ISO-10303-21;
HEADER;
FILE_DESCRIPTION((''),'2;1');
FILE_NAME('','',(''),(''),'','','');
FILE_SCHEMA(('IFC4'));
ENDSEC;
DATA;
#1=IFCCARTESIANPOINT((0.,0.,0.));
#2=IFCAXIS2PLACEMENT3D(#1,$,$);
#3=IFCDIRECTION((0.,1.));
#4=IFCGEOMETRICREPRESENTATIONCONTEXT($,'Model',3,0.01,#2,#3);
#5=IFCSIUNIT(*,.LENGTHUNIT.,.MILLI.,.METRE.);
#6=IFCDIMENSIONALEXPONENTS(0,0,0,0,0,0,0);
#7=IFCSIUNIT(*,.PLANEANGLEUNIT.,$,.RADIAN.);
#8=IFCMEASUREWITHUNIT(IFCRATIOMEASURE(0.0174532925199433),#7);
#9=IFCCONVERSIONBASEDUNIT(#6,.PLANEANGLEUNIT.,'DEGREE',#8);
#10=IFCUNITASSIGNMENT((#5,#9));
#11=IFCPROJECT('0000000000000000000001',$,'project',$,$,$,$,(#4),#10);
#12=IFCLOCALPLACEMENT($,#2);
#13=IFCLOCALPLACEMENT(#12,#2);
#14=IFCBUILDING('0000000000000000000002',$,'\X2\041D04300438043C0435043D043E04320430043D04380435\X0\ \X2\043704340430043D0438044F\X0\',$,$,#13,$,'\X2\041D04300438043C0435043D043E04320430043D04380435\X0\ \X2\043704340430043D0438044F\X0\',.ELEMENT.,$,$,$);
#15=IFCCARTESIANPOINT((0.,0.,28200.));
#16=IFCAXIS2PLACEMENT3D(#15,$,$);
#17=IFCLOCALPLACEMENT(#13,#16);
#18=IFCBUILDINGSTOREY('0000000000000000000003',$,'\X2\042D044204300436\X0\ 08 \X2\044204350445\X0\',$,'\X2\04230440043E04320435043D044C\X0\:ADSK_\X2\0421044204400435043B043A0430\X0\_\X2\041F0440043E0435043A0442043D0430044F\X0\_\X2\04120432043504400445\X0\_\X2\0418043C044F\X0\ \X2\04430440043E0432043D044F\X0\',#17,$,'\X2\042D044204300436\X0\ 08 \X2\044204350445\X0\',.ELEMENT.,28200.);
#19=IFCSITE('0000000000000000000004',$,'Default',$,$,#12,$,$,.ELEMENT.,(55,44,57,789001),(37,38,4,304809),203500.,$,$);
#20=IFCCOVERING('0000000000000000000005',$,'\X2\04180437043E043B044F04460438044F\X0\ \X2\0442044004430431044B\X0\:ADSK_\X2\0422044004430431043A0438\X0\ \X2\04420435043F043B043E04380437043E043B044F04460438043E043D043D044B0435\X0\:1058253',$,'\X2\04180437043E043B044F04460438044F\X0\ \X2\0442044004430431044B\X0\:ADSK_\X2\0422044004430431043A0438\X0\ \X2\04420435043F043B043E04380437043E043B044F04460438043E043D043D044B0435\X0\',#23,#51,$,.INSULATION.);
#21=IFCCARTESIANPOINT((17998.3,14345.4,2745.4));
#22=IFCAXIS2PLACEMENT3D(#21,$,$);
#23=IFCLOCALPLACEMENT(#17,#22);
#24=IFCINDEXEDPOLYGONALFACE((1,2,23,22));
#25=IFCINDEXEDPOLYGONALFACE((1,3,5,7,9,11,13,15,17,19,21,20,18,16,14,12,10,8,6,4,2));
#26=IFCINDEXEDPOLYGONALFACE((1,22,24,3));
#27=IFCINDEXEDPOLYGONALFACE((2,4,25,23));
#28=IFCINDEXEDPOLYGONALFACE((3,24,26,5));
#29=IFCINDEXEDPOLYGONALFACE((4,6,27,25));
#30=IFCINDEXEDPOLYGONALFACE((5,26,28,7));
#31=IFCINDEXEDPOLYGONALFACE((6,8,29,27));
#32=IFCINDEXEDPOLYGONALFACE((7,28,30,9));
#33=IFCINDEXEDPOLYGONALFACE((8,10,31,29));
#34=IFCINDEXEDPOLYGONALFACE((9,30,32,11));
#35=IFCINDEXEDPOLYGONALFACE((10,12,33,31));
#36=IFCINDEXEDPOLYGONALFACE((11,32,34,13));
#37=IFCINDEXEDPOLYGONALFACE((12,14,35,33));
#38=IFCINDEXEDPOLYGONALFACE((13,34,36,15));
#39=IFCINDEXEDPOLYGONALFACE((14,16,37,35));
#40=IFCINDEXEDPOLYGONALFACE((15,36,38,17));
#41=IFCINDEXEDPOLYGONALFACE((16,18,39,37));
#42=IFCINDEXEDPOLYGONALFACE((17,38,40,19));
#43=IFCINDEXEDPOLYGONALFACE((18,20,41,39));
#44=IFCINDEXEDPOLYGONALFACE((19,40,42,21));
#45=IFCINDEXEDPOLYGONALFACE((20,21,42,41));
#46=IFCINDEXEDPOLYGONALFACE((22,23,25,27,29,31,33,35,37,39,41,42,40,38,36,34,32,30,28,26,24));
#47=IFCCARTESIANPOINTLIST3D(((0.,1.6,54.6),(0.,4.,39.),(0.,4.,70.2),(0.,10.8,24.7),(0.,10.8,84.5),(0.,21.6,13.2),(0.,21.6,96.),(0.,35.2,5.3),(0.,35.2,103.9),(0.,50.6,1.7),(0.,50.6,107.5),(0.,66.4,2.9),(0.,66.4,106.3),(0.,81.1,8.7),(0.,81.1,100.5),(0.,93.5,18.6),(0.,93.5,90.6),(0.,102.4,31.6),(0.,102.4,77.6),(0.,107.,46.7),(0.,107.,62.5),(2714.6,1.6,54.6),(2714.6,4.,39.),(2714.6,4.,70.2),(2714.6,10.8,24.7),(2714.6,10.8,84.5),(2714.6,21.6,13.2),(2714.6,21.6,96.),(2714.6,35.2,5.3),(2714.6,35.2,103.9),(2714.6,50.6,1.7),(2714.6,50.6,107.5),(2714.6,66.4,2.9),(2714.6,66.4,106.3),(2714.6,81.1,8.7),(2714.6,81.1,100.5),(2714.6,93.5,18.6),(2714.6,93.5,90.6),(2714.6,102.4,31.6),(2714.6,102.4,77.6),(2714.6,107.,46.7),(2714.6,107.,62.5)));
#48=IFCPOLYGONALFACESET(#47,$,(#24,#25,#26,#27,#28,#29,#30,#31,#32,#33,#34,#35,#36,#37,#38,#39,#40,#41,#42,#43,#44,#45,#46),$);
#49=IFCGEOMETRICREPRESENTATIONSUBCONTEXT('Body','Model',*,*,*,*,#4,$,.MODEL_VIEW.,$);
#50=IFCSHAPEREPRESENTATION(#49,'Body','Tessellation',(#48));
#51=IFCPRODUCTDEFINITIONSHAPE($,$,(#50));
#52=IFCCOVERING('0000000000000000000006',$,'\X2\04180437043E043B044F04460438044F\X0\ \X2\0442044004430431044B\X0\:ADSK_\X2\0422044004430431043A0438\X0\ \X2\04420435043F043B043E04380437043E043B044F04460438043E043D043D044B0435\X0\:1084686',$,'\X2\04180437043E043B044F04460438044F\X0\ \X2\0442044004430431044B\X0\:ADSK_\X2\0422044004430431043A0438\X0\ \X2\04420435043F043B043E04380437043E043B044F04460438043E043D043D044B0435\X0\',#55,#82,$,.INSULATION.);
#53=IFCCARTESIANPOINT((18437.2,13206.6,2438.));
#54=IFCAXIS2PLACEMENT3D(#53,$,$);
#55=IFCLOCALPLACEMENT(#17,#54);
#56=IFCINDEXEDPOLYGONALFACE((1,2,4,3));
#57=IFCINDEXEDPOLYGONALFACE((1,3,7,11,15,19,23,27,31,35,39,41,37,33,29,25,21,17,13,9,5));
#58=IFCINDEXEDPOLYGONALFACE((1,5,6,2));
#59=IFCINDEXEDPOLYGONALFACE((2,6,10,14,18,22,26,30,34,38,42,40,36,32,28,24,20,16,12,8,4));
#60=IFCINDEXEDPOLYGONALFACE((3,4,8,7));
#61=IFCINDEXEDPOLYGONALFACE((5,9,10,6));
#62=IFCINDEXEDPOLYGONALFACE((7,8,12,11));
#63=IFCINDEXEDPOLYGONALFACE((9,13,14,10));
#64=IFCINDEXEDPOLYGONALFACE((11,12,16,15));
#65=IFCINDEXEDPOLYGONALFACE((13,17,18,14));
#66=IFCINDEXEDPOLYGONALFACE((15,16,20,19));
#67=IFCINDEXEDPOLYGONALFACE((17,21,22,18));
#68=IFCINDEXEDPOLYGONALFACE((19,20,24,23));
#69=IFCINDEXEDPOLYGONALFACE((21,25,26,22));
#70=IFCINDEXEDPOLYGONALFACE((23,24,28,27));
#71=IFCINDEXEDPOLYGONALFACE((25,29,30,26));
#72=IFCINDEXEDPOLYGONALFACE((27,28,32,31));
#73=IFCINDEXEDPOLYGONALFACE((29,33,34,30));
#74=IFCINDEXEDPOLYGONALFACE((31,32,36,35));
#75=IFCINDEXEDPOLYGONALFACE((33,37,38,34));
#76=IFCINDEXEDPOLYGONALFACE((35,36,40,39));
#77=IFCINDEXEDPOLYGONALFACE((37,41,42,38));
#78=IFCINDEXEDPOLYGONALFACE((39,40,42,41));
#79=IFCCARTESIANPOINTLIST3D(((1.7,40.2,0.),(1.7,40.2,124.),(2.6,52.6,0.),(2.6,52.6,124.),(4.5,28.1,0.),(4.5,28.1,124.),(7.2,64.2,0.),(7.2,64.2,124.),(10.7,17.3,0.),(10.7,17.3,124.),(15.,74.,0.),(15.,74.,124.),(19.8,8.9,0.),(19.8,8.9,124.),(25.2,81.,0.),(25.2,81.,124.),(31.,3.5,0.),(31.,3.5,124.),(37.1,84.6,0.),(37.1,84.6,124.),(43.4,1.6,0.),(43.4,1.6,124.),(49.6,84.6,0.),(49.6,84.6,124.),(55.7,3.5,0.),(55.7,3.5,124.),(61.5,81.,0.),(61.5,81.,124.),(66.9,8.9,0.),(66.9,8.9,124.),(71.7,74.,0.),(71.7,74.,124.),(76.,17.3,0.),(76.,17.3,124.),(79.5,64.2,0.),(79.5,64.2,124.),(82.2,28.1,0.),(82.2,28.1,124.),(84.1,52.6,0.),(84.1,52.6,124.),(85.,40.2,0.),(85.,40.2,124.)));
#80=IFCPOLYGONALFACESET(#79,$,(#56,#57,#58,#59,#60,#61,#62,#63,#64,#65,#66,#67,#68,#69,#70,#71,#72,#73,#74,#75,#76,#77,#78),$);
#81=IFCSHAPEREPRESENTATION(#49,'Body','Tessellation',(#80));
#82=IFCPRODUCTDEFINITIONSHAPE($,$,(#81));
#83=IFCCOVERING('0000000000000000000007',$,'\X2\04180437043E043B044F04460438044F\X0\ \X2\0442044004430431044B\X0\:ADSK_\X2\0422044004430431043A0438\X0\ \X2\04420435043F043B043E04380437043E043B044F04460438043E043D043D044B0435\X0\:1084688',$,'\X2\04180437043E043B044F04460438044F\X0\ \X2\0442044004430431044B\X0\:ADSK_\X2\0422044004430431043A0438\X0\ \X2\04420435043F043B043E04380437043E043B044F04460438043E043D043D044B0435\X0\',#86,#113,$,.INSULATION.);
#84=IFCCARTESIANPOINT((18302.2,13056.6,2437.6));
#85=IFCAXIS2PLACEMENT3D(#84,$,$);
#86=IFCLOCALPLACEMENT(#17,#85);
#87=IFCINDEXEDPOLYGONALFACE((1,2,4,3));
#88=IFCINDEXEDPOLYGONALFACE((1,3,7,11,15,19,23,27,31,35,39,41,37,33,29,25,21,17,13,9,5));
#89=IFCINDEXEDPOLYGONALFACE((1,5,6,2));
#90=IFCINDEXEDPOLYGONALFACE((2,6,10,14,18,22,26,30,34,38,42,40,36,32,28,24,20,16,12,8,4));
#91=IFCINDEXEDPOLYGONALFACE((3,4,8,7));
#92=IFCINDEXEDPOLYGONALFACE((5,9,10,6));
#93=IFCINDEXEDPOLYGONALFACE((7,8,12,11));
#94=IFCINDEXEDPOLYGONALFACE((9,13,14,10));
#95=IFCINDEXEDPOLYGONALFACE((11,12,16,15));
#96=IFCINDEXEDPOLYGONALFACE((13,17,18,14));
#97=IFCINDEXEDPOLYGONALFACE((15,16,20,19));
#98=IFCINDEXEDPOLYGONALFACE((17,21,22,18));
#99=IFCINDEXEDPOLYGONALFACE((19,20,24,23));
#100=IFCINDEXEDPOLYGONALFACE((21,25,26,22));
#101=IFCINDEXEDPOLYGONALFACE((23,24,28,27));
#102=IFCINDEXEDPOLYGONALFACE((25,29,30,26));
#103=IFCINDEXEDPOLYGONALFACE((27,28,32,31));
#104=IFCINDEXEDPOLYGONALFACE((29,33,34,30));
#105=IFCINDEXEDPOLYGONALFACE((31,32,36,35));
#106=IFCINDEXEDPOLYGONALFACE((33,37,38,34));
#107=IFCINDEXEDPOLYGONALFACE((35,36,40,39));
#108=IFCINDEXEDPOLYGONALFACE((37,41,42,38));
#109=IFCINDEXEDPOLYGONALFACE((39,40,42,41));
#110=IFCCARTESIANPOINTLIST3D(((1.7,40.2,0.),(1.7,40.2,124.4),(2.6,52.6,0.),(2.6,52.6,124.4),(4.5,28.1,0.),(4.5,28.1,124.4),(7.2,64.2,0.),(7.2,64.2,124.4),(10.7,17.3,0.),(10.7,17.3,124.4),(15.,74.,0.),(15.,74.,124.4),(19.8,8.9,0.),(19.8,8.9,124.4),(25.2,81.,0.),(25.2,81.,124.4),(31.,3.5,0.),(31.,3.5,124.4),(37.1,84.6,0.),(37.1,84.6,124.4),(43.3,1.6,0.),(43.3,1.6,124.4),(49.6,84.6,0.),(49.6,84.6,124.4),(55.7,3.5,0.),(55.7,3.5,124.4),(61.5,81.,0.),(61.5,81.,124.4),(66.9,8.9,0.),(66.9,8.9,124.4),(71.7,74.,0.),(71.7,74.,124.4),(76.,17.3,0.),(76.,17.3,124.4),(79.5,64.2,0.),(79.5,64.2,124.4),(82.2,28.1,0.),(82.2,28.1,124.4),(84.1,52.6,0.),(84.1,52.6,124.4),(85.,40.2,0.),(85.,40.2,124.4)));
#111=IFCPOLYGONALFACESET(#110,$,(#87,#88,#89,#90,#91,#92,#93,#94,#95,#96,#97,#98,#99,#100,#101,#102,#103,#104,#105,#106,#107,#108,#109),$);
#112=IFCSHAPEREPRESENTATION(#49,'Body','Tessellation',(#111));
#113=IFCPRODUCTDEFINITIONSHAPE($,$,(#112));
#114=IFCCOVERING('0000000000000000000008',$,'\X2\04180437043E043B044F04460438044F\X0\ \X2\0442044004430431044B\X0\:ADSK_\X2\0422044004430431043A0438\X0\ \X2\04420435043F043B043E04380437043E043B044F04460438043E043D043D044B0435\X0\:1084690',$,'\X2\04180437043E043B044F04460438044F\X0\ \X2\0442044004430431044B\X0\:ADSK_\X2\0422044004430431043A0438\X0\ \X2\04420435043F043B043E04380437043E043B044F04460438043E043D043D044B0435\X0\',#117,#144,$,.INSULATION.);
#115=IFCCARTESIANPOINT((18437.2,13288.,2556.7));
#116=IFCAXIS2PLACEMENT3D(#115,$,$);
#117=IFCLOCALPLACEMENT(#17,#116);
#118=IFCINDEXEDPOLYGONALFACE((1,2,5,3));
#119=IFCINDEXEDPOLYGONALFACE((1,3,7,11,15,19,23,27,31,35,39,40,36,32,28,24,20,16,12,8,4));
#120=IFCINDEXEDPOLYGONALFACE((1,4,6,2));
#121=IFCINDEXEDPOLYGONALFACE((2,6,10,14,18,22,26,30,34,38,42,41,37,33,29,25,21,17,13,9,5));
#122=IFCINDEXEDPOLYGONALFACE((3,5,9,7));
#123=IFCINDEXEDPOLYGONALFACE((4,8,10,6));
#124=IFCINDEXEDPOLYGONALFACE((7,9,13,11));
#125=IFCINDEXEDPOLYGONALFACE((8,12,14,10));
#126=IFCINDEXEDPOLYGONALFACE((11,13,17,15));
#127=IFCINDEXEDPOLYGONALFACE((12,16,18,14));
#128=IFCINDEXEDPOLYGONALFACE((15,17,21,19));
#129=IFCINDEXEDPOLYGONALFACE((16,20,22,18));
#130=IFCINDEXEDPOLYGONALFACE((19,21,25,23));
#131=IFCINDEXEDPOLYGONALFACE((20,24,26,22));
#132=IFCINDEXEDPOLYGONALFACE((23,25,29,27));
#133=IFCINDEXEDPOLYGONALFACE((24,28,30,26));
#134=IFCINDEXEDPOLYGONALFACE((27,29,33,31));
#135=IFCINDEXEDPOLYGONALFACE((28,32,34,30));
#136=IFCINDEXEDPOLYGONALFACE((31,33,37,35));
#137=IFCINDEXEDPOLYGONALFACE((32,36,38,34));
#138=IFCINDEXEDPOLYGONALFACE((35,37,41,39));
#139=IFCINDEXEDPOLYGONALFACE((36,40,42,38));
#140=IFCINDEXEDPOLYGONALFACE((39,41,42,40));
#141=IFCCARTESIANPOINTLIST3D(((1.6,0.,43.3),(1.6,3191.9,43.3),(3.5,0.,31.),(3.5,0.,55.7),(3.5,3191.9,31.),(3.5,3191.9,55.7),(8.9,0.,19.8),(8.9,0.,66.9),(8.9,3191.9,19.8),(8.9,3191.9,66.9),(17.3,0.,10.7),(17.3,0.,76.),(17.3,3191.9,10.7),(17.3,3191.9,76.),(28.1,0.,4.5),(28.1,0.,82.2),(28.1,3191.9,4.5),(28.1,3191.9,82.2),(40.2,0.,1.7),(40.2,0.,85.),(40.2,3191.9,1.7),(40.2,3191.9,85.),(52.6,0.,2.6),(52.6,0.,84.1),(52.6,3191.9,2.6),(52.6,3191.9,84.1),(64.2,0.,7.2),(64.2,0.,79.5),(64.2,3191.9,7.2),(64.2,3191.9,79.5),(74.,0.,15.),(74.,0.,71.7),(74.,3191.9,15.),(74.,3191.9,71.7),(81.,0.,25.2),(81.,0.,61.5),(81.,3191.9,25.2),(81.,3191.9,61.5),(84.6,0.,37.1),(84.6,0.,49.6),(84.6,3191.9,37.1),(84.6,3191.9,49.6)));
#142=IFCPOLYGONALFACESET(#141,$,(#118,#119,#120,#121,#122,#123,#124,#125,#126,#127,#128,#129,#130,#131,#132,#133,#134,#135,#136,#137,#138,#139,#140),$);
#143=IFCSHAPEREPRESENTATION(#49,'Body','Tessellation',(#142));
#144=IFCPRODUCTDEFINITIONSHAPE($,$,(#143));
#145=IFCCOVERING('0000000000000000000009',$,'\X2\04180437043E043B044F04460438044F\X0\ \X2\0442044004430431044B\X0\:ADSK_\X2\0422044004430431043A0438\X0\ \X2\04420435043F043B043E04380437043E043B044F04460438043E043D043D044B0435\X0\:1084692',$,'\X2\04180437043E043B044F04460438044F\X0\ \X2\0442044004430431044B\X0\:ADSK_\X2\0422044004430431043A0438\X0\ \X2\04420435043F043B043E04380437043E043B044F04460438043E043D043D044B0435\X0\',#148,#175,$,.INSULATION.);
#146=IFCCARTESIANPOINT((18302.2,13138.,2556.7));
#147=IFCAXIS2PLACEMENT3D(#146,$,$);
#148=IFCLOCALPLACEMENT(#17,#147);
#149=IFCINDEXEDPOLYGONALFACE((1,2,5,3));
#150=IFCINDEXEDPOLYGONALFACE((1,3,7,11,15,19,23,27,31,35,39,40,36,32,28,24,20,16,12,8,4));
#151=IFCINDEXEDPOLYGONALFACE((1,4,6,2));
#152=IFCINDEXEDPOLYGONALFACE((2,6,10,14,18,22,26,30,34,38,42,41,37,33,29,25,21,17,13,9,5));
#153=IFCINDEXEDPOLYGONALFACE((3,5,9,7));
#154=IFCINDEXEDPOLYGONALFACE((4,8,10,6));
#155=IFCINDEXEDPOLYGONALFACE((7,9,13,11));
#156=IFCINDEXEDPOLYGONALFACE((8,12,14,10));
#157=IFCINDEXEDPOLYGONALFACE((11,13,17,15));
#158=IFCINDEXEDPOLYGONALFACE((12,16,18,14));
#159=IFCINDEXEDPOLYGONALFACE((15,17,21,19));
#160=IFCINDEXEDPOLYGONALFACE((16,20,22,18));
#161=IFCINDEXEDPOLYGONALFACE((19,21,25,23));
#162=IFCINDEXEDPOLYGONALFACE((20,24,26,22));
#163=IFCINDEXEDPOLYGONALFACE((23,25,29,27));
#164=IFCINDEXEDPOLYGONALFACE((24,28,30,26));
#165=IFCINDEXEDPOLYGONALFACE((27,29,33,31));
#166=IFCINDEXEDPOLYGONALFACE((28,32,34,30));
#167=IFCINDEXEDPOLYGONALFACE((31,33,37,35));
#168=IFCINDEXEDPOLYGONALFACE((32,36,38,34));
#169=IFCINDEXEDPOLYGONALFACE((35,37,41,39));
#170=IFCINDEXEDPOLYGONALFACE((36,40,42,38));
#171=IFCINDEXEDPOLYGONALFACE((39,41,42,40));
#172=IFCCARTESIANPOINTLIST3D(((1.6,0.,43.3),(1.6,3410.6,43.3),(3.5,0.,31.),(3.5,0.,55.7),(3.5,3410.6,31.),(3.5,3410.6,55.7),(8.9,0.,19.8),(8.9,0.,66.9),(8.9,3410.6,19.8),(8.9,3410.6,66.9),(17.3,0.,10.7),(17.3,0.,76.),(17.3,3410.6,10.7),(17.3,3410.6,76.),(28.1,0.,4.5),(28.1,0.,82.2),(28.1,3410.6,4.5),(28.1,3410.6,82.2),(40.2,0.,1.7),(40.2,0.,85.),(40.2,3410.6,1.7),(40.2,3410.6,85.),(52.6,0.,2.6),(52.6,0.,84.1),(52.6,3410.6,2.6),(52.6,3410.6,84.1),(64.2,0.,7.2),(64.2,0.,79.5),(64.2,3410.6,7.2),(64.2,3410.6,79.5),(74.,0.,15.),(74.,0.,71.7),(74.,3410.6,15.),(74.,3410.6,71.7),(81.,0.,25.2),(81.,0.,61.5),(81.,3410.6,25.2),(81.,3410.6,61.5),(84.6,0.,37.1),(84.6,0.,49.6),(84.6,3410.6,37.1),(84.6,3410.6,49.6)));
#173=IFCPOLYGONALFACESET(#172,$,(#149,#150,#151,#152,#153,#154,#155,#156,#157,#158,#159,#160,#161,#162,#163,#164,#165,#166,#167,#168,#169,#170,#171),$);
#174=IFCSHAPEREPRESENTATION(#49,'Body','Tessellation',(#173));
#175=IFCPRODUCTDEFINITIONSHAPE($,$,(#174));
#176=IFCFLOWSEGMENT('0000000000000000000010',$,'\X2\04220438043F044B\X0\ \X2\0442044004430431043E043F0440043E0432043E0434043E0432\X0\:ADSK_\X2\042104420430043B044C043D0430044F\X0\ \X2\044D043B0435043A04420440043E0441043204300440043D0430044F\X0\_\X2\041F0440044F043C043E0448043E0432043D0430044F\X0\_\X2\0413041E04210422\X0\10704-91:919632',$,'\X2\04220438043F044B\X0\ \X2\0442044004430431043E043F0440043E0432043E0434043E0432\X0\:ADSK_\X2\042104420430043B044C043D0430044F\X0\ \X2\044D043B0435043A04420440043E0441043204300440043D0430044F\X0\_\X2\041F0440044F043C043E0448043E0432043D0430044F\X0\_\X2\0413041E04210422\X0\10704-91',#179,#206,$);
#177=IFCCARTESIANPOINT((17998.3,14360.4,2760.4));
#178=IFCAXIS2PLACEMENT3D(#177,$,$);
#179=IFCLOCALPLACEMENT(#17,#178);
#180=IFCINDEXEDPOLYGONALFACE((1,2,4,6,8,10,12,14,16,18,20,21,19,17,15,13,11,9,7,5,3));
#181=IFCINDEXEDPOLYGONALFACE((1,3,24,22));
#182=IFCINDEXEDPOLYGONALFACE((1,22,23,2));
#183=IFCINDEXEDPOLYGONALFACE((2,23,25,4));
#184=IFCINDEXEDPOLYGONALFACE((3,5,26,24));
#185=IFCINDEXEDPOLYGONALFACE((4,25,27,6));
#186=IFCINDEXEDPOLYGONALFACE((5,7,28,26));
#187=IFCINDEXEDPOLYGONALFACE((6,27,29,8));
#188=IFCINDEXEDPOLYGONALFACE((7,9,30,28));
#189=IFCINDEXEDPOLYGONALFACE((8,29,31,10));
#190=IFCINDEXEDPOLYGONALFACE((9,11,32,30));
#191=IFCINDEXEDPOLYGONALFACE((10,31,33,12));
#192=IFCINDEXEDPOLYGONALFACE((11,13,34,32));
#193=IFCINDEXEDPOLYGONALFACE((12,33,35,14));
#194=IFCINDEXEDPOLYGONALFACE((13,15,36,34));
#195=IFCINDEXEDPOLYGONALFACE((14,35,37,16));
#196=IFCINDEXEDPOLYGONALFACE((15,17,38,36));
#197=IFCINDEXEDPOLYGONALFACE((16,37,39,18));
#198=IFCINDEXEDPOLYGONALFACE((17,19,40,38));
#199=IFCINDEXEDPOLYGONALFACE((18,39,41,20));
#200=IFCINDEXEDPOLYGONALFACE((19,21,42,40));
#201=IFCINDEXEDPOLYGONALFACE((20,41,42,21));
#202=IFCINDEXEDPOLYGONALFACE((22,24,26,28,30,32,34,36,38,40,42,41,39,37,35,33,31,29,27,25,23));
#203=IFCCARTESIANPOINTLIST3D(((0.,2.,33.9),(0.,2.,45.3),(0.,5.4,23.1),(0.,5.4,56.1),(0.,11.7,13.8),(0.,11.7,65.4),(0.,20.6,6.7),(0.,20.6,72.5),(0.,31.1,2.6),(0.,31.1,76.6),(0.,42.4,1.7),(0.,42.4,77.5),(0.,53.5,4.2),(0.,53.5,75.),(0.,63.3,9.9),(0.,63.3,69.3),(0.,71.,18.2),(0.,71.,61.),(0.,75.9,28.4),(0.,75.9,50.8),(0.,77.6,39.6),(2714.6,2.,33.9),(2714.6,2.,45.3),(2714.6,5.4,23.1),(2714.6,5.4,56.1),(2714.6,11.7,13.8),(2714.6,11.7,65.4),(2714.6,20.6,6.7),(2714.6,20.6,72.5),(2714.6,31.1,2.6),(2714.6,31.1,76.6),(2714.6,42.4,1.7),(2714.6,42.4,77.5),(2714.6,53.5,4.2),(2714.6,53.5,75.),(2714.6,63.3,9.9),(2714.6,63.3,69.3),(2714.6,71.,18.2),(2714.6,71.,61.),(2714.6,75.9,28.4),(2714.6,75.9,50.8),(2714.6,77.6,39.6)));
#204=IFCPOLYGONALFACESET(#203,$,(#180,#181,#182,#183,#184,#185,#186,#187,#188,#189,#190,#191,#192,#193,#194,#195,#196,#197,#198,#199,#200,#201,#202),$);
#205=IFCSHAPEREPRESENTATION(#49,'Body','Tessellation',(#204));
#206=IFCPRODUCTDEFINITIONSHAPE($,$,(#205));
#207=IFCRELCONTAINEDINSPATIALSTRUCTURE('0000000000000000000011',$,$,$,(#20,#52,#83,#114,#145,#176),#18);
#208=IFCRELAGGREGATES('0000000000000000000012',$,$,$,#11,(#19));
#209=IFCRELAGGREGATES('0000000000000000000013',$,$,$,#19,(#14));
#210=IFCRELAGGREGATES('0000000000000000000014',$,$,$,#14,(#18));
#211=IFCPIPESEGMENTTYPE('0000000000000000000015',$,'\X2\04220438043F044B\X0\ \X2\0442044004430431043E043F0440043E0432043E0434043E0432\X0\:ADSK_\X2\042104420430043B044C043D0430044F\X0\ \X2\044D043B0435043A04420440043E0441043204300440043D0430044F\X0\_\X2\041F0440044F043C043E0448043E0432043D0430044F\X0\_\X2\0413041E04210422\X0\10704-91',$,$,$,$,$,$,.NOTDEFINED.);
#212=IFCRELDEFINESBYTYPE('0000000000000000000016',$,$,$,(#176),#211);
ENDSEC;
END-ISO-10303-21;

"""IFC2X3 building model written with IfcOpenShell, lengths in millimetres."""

from ifc_helpers import new_model, entity, si_unit, converted_unit, direction, frame, origin, origin_2d_with_axis, place, context, subcontext, project, spatial, circle, extrude, type_object, element, save


model = new_model("IFC2X3")

# Units and contexts
model_context = context("Model", 3, precision=0.01, world=origin(), true_north=direction((0.0, 1.0)))
body_context = subcontext(model_context, "Body", "Model", "MODEL_VIEW")
ifc_project = project(units=[si_unit("LENGTHUNIT", "METRE", prefix="MILLI"), converted_unit("PLANEANGLEUNIT", "DEGREE", entity("IfcRatioMeasure", 0.0174532925199433), si_unit("PLANEANGLEUNIT", "RADIAN"), dimensions=[0, 0, 0, 0, 0, 0, 0])], contexts=[model_context])

# Site, building, storey
site_placement = place(None, origin())
site = spatial("IfcSite", under=ifc_project, at=site_placement, Name="Default", CompositionType="ELEMENT", RefLatitude=(55, 44, 57, 789001), RefLongitude=(37, 38, 4, 304809), RefElevation=203500.0)
building_placement = place(site_placement, origin())
building = spatial("IfcBuilding", under=site, at=building_placement, Name="Наименование здания", LongName="Наименование здания", CompositionType="ELEMENT")
storey_placement = place(building_placement, frame((0.0, 0.0, 28200.0)))
storey = spatial("IfcBuildingStorey", under=building, at=storey_placement, Name="Этаж 08 тех", ObjectType="Уровень:ADSK_Стрелка_Проектная_Вверх_Имя уровня", LongName="Этаж 08 тех", CompositionType="ELEMENT", Elevation=28200.0)

# Coverings
covering_1_placement = place(storey_placement, frame((17998.3, 14345.4, 2745.4)))
element("IfcCovering", 1, at=covering_1_placement, inside=storey, Name="Изоляция трубы:ADSK_Трубки теплоизоляционные:1058253", ObjectType="Изоляция трубы:ADSK_Трубки теплоизоляционные", PredefinedType="INSULATION", context=body_context, shape_type="SweptSolid", body=[
    extrude(circle(Radius=53.0, at=origin_2d_with_axis()), frame((0.0, 54.6, 54.6), z_axis=(1.0, 0.0, 0.0), x_axis=(0.0, -1.0, 0.0)), (0.0, 0.0, 1.0), 2714.6),
])
covering_2_placement = place(storey_placement, frame((18437.2, 13206.6, 2438.0)))
element("IfcCovering", 2, at=covering_2_placement, inside=storey, Name="Изоляция трубы:ADSK_Трубки теплоизоляционные:1084686", ObjectType="Изоляция трубы:ADSK_Трубки теплоизоляционные", PredefinedType="INSULATION", context=body_context, shape_type="SweptSolid", body=[
    extrude(circle(Radius=41.8, at=origin_2d_with_axis()), frame((43.4, 43.4, 0.0), z_axis=(0.0, 0.0, 1.0), x_axis=(0.0, -1.0, 0.0)), (0.0, 0.0, 1.0), 124.0),
])
covering_3_placement = place(storey_placement, frame((18302.2, 13056.6, 2437.6)))
element("IfcCovering", 3, at=covering_3_placement, inside=storey, Name="Изоляция трубы:ADSK_Трубки теплоизоляционные:1084688", ObjectType="Изоляция трубы:ADSK_Трубки теплоизоляционные", PredefinedType="INSULATION", context=body_context, shape_type="SweptSolid", body=[
    extrude(circle(Radius=41.8, at=origin_2d_with_axis()), frame((43.4, 43.4, 0.0), z_axis=(0.0, 0.0, 1.0), x_axis=(0.0, -1.0, 0.0)), (0.0, 0.0, 1.0), 124.4),
])
covering_4_placement = place(storey_placement, frame((18437.2, 13288.0, 2556.7)))
element("IfcCovering", 4, at=covering_4_placement, inside=storey, Name="Изоляция трубы:ADSK_Трубки теплоизоляционные:1084690", ObjectType="Изоляция трубы:ADSK_Трубки теплоизоляционные", PredefinedType="INSULATION", context=body_context, shape_type="SweptSolid", body=[
    extrude(circle(Radius=41.8, at=origin_2d_with_axis()), frame((43.4, 0.0, 43.4), z_axis=(0.0, 1.0, 0.0), x_axis=(-1.0, 0.0, 0.0)), (0.0, 0.0, 1.0), 3191.9),
])
covering_5_placement = place(storey_placement, frame((18302.2, 13138.0, 2556.7)))
element("IfcCovering", 5, at=covering_5_placement, inside=storey, Name="Изоляция трубы:ADSK_Трубки теплоизоляционные:1084692", ObjectType="Изоляция трубы:ADSK_Трубки теплоизоляционные", PredefinedType="INSULATION", context=body_context, shape_type="SweptSolid", body=[
    extrude(circle(Radius=41.8, at=origin_2d_with_axis()), frame((43.4, 0.0, 43.4), z_axis=(0.0, 1.0, 0.0), x_axis=(-1.0, 0.0, 0.0)), (0.0, 0.0, 1.0), 3410.6),
])

# Flow segment
pipe_segment_type_1 = type_object("IfcPipeSegmentType", Name="Типы трубопроводов:ADSK_Стальная электросварная_Прямошовная_ГОСТ10704-91", PredefinedType="NOTDEFINED")
flow_segment_1_placement = place(storey_placement, frame((17998.3, 14360.4, 2760.4)))
element("IfcFlowSegment", 6, at=flow_segment_1_placement, inside=storey, type_object=pipe_segment_type_1, Name="Типы трубопроводов:ADSK_Стальная электросварная_Прямошовная_ГОСТ10704-91:919632", ObjectType="Типы трубопроводов:ADSK_Стальная электросварная_Прямошовная_ГОСТ10704-91", context=body_context, shape_type="SweptSolid", body=[
    extrude(circle(Radius=38.0, at=origin_2d_with_axis()), frame((0.0, 39.6, 39.6), z_axis=(1.0, 0.0, 0.0), x_axis=(0.0, 1.0, 0.0)), (0.0, 0.0, 1.0), 2714.6),
])

save(model, "model.ifc")
